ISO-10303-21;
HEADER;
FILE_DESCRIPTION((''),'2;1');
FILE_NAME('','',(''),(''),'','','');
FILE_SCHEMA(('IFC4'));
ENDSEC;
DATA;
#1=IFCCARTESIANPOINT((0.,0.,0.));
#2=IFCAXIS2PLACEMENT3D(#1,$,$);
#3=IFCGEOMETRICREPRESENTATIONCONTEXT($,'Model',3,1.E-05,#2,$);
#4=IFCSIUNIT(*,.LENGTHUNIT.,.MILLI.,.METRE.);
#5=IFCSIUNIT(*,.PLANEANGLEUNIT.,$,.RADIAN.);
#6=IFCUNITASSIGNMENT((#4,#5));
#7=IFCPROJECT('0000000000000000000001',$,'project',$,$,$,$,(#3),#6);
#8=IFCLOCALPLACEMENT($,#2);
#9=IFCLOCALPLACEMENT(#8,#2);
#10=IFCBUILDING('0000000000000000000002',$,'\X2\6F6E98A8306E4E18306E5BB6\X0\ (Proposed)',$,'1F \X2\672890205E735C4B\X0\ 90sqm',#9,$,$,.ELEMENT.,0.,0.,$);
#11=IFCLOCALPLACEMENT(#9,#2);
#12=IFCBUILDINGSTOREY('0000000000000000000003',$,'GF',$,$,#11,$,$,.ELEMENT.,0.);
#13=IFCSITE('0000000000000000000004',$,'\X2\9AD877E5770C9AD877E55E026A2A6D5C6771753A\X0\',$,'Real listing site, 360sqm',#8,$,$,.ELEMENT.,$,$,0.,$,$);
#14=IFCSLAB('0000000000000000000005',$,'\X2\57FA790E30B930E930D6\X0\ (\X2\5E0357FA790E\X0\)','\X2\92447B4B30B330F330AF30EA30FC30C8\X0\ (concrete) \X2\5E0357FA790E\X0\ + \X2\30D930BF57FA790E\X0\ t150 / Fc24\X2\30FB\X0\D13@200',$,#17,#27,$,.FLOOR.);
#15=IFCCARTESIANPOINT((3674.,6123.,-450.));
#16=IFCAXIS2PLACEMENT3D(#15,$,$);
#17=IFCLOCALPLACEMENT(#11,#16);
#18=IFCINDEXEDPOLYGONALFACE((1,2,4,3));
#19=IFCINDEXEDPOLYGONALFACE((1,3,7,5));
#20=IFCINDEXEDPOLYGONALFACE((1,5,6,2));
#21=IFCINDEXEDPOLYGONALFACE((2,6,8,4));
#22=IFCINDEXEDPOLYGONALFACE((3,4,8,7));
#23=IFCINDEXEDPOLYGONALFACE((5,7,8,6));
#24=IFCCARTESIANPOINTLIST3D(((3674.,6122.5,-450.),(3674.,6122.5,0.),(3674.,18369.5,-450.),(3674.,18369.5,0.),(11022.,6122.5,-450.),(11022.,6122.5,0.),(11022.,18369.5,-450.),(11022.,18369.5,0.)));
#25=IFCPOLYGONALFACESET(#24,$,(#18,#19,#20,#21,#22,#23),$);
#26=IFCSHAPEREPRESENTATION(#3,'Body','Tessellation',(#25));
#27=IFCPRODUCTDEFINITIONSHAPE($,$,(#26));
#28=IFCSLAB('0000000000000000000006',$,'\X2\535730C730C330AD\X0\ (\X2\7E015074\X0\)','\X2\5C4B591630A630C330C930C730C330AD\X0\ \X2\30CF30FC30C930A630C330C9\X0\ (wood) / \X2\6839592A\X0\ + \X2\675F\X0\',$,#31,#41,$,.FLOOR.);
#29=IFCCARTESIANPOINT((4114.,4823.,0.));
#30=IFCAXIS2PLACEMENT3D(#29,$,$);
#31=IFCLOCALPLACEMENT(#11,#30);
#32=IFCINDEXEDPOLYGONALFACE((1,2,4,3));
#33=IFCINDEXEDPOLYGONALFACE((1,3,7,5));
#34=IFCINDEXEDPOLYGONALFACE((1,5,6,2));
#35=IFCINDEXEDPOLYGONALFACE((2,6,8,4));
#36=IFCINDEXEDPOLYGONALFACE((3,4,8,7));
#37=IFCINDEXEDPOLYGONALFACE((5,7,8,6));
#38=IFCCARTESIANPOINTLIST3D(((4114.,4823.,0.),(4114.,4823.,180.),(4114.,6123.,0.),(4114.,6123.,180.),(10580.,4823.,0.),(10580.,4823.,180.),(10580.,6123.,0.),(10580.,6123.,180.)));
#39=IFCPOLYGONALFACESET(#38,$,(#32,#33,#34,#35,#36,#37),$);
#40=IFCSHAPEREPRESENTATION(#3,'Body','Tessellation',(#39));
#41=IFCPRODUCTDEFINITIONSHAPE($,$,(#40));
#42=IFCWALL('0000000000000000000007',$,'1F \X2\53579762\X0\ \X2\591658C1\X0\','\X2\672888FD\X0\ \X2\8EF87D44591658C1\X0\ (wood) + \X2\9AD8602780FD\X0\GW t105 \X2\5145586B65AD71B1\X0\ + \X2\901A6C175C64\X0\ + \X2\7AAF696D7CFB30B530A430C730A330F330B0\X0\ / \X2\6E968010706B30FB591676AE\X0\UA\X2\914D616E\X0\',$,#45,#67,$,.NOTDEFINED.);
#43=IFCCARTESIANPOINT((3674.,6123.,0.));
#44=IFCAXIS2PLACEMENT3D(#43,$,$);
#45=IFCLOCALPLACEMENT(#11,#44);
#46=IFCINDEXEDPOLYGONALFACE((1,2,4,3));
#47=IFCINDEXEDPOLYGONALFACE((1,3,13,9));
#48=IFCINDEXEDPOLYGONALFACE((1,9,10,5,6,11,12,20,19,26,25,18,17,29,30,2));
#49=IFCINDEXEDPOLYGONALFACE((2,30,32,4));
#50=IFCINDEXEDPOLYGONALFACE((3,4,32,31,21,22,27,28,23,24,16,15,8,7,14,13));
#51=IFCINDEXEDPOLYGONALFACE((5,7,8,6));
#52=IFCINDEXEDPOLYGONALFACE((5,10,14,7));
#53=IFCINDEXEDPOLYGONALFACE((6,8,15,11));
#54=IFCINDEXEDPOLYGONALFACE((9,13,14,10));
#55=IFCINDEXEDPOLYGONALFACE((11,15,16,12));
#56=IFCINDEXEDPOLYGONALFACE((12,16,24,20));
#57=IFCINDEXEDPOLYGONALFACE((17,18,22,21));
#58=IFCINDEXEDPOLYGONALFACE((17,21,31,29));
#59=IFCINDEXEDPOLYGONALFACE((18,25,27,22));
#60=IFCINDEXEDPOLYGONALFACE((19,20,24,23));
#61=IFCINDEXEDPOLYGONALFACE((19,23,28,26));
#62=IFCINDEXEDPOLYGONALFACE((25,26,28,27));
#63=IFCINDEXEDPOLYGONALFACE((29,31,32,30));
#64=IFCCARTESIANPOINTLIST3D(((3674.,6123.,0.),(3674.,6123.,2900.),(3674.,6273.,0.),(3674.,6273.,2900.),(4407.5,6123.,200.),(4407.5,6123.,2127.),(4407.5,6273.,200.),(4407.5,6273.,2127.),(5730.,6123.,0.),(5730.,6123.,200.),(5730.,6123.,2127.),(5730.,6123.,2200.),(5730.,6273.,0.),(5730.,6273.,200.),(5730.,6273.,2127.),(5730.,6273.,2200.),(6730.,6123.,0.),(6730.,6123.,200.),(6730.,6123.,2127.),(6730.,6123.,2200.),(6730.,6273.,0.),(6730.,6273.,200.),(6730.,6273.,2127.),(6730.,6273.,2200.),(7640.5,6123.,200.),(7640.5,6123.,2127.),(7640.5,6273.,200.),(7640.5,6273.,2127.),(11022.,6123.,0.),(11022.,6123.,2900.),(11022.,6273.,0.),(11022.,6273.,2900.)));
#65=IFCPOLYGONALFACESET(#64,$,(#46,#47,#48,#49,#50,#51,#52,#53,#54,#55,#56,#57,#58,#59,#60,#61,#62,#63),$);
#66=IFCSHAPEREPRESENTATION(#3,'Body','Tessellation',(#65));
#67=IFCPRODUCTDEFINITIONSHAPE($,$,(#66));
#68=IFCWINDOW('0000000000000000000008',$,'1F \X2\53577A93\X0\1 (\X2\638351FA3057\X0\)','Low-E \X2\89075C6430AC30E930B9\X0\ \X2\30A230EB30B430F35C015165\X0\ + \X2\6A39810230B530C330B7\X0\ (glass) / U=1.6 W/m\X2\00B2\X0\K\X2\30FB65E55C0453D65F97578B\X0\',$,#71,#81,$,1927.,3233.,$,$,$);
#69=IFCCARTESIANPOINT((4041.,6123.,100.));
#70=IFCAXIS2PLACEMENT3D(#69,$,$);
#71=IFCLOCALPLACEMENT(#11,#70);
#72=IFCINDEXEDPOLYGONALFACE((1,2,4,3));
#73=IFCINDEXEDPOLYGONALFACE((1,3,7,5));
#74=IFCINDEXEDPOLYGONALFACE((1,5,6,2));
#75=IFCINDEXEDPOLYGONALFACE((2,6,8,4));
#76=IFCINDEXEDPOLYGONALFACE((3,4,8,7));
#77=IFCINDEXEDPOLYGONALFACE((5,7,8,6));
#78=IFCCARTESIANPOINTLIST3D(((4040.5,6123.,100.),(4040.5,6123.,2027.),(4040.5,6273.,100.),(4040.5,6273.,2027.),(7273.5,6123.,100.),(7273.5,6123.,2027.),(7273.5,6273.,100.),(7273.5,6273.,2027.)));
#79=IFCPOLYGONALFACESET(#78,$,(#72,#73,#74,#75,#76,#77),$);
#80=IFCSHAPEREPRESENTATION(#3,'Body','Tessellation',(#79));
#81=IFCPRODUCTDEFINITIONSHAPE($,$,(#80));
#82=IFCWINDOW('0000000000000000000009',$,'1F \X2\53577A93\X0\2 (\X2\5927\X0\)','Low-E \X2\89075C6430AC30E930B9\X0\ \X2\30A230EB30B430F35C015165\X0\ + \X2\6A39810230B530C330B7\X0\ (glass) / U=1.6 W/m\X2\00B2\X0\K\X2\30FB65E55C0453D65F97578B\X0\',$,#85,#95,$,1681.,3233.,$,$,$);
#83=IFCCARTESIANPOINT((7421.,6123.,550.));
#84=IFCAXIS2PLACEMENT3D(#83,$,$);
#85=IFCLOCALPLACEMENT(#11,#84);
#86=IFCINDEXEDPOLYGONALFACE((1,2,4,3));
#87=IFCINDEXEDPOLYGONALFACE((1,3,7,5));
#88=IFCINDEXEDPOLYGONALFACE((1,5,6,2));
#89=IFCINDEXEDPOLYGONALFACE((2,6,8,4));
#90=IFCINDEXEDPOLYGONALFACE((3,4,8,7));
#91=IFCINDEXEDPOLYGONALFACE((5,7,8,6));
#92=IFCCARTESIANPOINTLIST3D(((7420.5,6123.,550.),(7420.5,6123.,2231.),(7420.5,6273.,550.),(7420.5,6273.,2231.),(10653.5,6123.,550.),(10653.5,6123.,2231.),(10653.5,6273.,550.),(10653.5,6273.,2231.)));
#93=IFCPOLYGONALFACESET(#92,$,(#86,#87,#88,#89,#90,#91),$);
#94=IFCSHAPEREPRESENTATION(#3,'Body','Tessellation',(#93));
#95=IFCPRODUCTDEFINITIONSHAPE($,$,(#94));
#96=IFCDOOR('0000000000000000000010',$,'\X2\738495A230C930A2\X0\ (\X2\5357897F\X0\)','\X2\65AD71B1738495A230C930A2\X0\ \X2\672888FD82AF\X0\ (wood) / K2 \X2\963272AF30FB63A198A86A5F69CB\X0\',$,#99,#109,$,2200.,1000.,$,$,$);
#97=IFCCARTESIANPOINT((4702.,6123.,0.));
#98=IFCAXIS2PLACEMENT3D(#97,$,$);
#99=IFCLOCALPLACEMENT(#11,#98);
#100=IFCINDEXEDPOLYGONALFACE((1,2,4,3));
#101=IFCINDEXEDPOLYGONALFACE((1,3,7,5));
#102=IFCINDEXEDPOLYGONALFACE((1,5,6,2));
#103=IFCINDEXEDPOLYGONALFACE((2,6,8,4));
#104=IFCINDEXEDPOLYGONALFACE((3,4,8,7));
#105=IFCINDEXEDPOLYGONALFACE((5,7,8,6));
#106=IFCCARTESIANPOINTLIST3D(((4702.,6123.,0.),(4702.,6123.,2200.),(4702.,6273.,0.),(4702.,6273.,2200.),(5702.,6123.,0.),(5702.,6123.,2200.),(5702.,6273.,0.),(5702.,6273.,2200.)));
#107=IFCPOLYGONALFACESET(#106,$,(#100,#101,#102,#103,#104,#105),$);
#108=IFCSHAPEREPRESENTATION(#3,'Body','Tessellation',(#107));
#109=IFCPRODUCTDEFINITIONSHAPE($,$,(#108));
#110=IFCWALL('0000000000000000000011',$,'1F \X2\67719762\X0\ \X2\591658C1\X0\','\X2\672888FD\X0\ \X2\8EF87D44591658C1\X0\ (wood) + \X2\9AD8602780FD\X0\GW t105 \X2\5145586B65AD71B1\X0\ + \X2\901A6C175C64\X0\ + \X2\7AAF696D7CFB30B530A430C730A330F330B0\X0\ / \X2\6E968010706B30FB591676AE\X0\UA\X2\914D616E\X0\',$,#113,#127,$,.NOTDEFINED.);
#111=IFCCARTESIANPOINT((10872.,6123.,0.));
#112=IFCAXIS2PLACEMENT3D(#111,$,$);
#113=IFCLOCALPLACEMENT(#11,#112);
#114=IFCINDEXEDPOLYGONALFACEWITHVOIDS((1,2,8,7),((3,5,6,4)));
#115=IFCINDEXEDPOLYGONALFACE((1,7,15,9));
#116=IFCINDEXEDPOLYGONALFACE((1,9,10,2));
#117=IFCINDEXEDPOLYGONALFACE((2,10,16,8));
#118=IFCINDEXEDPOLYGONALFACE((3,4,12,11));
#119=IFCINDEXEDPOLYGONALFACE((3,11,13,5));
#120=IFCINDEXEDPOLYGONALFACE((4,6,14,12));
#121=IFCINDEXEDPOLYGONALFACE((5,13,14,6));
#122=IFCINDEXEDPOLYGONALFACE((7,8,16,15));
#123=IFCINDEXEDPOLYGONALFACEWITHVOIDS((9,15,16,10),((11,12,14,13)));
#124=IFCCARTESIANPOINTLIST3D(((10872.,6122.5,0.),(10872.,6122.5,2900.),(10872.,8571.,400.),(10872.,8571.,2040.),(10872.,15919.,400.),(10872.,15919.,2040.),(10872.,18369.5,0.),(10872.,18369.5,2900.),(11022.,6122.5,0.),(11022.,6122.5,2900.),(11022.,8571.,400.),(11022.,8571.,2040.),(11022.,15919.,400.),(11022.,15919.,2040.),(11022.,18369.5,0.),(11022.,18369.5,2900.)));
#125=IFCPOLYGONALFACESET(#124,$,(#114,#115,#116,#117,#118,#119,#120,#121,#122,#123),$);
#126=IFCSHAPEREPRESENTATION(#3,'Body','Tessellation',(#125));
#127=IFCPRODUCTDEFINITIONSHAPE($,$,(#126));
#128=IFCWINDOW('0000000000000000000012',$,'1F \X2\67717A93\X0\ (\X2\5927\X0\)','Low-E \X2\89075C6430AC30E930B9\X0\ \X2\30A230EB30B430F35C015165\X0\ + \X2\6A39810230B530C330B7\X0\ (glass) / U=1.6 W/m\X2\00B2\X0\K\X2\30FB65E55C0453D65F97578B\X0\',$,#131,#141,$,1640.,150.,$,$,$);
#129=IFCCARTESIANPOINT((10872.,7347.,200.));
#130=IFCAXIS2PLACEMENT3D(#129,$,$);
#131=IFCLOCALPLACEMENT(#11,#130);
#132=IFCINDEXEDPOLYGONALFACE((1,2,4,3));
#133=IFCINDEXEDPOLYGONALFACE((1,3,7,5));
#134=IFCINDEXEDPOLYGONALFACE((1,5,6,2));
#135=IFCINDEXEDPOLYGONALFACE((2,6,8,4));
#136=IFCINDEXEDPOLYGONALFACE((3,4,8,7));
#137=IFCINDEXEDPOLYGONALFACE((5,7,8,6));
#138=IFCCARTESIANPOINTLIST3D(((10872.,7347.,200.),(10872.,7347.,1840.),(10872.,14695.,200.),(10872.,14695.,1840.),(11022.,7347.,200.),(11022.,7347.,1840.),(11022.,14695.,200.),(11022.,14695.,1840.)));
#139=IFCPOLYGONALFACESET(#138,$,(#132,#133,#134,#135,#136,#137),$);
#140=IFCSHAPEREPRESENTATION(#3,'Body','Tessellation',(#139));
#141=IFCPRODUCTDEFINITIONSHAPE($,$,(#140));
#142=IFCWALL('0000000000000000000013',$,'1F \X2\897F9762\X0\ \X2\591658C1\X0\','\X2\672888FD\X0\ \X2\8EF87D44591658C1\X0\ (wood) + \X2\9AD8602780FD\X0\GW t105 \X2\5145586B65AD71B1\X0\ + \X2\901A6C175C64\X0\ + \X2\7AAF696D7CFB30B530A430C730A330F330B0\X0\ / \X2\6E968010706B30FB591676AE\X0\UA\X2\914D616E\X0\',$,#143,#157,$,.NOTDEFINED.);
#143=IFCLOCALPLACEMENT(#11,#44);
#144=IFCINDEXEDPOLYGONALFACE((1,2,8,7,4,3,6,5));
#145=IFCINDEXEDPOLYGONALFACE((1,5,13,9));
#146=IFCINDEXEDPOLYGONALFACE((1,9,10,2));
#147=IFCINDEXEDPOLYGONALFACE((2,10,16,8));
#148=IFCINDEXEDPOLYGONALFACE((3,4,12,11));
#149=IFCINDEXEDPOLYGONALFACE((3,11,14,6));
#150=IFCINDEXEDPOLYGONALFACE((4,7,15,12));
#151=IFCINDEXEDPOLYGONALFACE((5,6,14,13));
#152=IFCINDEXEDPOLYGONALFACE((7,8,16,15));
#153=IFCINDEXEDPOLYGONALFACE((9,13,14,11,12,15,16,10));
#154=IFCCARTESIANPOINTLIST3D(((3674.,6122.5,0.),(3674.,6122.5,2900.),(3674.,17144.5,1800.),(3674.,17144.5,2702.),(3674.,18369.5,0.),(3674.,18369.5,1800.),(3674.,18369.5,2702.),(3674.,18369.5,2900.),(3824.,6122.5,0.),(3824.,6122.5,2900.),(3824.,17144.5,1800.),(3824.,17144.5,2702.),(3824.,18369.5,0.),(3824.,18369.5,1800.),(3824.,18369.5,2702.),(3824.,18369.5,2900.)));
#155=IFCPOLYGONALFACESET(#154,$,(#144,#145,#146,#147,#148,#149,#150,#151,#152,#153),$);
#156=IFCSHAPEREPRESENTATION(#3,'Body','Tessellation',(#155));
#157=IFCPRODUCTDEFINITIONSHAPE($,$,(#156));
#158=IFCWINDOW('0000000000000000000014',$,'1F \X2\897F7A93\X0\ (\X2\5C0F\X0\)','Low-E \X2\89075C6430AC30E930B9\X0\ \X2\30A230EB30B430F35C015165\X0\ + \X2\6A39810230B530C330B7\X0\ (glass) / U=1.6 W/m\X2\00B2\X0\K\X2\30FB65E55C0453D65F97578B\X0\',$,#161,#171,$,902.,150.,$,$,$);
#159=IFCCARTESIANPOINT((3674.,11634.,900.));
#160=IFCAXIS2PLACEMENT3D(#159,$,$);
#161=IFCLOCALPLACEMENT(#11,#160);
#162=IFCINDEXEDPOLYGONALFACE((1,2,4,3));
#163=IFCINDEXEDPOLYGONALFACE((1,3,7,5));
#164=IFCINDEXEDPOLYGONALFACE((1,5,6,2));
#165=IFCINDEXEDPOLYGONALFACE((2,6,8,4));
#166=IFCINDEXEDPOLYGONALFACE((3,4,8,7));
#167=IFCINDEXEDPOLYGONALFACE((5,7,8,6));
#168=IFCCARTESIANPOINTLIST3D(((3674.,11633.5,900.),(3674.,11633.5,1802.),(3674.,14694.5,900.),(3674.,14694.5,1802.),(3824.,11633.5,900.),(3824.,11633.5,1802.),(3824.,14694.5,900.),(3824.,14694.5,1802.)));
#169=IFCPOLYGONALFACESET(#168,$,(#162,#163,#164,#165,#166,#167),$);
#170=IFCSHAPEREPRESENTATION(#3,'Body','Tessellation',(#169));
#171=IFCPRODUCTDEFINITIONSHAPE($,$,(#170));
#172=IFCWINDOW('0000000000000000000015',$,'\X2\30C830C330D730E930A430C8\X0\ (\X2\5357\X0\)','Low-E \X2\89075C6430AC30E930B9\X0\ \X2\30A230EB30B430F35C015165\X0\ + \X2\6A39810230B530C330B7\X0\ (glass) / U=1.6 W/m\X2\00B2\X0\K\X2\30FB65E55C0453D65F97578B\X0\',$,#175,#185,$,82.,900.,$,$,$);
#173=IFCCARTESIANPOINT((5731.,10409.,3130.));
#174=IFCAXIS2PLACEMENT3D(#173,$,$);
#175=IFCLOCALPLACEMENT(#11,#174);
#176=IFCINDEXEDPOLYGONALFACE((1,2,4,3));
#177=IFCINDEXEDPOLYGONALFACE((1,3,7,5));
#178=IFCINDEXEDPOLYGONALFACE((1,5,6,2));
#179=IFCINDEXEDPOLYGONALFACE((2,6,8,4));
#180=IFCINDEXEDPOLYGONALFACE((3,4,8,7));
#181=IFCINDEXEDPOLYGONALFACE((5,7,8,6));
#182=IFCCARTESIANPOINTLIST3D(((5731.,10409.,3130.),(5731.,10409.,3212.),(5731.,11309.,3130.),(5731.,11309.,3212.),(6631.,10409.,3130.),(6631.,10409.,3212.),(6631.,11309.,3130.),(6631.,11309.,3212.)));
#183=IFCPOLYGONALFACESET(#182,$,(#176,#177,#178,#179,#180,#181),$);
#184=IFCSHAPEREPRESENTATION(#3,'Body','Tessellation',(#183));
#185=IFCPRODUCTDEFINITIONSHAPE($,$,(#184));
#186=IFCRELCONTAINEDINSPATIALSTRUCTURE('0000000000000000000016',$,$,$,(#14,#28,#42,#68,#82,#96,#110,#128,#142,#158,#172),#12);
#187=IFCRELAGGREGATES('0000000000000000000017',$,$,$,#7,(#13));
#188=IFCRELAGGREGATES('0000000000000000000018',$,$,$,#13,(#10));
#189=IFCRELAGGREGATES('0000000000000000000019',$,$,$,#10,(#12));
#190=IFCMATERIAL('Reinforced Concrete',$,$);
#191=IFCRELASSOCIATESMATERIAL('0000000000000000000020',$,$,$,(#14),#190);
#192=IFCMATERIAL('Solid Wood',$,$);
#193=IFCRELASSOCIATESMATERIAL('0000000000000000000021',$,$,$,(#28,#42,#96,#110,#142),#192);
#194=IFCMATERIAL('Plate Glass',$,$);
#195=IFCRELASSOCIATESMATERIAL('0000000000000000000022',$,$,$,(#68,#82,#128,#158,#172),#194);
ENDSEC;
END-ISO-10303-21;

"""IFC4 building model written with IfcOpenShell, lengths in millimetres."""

from ifc_helpers import new_model, si_unit, frame, frame_2d, origin, place, context, project, spatial, rectangle, extrude, material, element, fill, save


model = new_model("IFC4")

# Units and contexts
model_context = context("Model", 3, precision=1e-05, world=origin())
ifc_project = project(units=[si_unit("LENGTHUNIT", "METRE", prefix="MILLI"), si_unit("PLANEANGLEUNIT", "RADIAN")], contexts=[model_context])

# Site, building, storey
site_placement = place(None, origin())
site = spatial("IfcSite", under=ifc_project, at=site_placement, Name="高知県高知市横浜東町", ObjectType="Real listing site, 360sqm", CompositionType="ELEMENT", RefElevation=0.0)
building_placement = place(site_placement, origin())
building = spatial("IfcBuilding", under=site, at=building_placement, Name="潮風の丘の家 (Proposed)", ObjectType="1F 木造平屋 90sqm", CompositionType="ELEMENT", ElevationOfRefHeight=0.0, ElevationOfTerrain=0.0)
storey_placement = place(building_placement, origin())
storey = spatial("IfcBuildingStorey", under=building, at=storey_placement, Name="GF", CompositionType="ELEMENT", Elevation=0.0)

# Slabs
ifc_material_1 = material(Name="Reinforced Concrete")
slab_1_placement = place(storey_placement, frame((3674.0, 6123.0, -450.0)))
element("IfcSlab", 1, at=slab_1_placement, inside=storey, material=ifc_material_1, Name="基礎スラブ (布基礎)", Description="鉄筋コンクリート (concrete) 布基礎 + ベタ基礎 t150 / Fc24・D13@200", PredefinedType="FLOOR", context=model_context, shape_type="SweptSolid", body=[
    extrude(rectangle(XDim=7348.0, YDim=12247.0, at=frame_2d((3674.0, 6123.0))), frame((3674.0, 6123.0, -450.0)), (0.0, 0.0, 1.0), 450.0),
])
ifc_material_2 = material(Name="Solid Wood")
slab_2_placement = place(storey_placement, frame((4114.0, 4823.0, 0.0)))
element("IfcSlab", 2, at=slab_2_placement, inside=storey, material=ifc_material_2, Name="南デッキ (縁側)", Description="屋外ウッドデッキ ハードウッド (wood) / 根太 + 束", PredefinedType="FLOOR", context=model_context, shape_type="SweptSolid", body=[
    extrude(rectangle(XDim=6466.0, YDim=1300.0, at=frame_2d((3233.0, 650.0))), frame((4114.0, 4823.0, 0.0)), (0.0, 0.0, 1.0), 180.0),
])

# Wall, openings, windows, door
wall_1_placement = place(storey_placement, frame((3674.0, 6123.0, 0.0)))
wall_1 = element("IfcWall", 3, at=wall_1_placement, inside=storey, material=ifc_material_2, Name="1F 南面 外壁", Description="木製 軸組外壁 (wood) + 高性能GW t105 充填断熱 + 通気層 + 窯業系サイディング / 準耐火・外皮UA配慮", PredefinedType="NOTDEFINED", context=model_context, shape_type="SweptSolid", body=[
    extrude(rectangle(XDim=7348.0, YDim=150.0, at=frame_2d((3674.0, 75.0))), frame((3674.0, 6123.0, 0.0)), (0.0, 0.0, 1.0), 2900.0),
])
opening_1_placement = place(storey_placement, frame((4041.0, 6123.0, 100.0)))
opening_1 = element("IfcOpeningElement", 4, at=opening_1_placement, cuts=wall_1, PredefinedType="NOTDEFINED", context=model_context, shape_type="SweptSolid", body=[
    extrude(rectangle(XDim=3233.0, YDim=150.0, at=frame_2d((1616.0, 75.0))), frame((4041.0, 6123.0, 100.0)), (0.0, 0.0, 1.0), 1927.0),
])
opening_2_placement = place(storey_placement, frame((7421.0, 6123.0, 550.0)))
opening_2 = element("IfcOpeningElement", 5, at=opening_2_placement, cuts=wall_1, PredefinedType="NOTDEFINED", context=model_context, shape_type="SweptSolid", body=[
    extrude(rectangle(XDim=3233.0, YDim=150.0, at=frame_2d((1616.0, 75.0))), frame((7421.0, 6123.0, 550.0)), (0.0, 0.0, 1.0), 1681.0),
])
opening_3_placement = place(storey_placement, frame((4702.0, 6123.0, 0.0)))
opening_3 = element("IfcOpeningElement", 6, at=opening_3_placement, cuts=wall_1, PredefinedType="NOTDEFINED", context=model_context, shape_type="SweptSolid", body=[
    extrude(rectangle(XDim=1000.0, YDim=150.0, at=frame_2d((500.0, 75.0))), frame((4702.0, 6123.0, 0.0)), (0.0, 0.0, 1.0), 2200.0),
])
ifc_material_3 = material(Name="Plate Glass")
window_1_placement = place(storey_placement, frame((4041.0, 6123.0, 100.0)))
window_1 = element("IfcWindow", 7, at=window_1_placement, inside=storey, material=ifc_material_3, Name="1F 南窓1 (掃出し)", Description="Low-E 複層ガラス アルゴン封入 + 樹脂サッシ (glass) / U=1.6 W/m²K・日射取得型", OverallHeight=1927.0, OverallWidth=3233.0, context=model_context, shape_type="SweptSolid", body=[
    extrude(rectangle(XDim=3233.0, YDim=150.0, at=frame_2d((1616.0, 75.0))), frame((4041.0, 6123.0, 100.0)), (0.0, 0.0, 1.0), 1927.0),
])
fill(opening_1, window_1)
window_2_placement = place(storey_placement, frame((7421.0, 6123.0, 550.0)))
window_2 = element("IfcWindow", 8, at=window_2_placement, inside=storey, material=ifc_material_3, Name="1F 南窓2 (大)", Description="Low-E 複層ガラス アルゴン封入 + 樹脂サッシ (glass) / U=1.6 W/m²K・日射取得型", OverallHeight=1681.0, OverallWidth=3233.0, context=model_context, shape_type="SweptSolid", body=[
    extrude(rectangle(XDim=3233.0, YDim=150.0, at=frame_2d((1616.0, 75.0))), frame((7421.0, 6123.0, 550.0)), (0.0, 0.0, 1.0), 1681.0),
])
fill(opening_2, window_2)
door_placement = place(storey_placement, frame((4702.0, 6123.0, 0.0)))
door = element("IfcDoor", 9, at=door_placement, inside=storey, material=ifc_material_2, Name="玄関ドア (南西)", Description="断熱玄関ドア 木製芯 (wood) / K2 防犯・採風機構", OverallHeight=2200.0, OverallWidth=1000.0, context=model_context, shape_type="SweptSolid", body=[
    extrude(rectangle(XDim=1000.0, YDim=150.0, at=frame_2d((500.0, 75.0))), frame((4702.0, 6123.0, 0.0)), (0.0, 0.0, 1.0), 2200.0),
])
fill(opening_3, door)

# Walls, openings, windows
wall_2_placement = place(storey_placement, frame((10872.0, 6123.0, 0.0)))
wall_2 = element("IfcWall", 10, at=wall_2_placement, inside=storey, material=ifc_material_2, Name="1F 東面 外壁", Description="木製 軸組外壁 (wood) + 高性能GW t105 充填断熱 + 通気層 + 窯業系サイディング / 準耐火・外皮UA配慮", PredefinedType="NOTDEFINED", context=model_context, shape_type="SweptSolid", body=[
    extrude(rectangle(XDim=150.0, YDim=12247.0, at=frame_2d((75.0, 6123.0))), frame((10872.0, 6123.0, 0.0)), (0.0, 0.0, 1.0), 2900.0),
])
opening_4_placement = place(storey_placement, frame((10872.0, 7347.0, 200.0)))
opening_4 = element("IfcOpeningElement", 11, at=opening_4_placement, cuts=wall_2, PredefinedType="NOTDEFINED", context=model_context, shape_type="SweptSolid", body=[
    extrude(rectangle(XDim=150.0, YDim=7348.0, at=frame_2d((75.0, 3674.0))), frame((10872.0, 7347.0, 200.0)), (0.0, 0.0, 1.0), 1640.0),
])
window_3_placement = place(storey_placement, frame((10872.0, 7347.0, 200.0)))
window_3 = element("IfcWindow", 12, at=window_3_placement, inside=storey, material=ifc_material_3, Name="1F 東窓 (大)", Description="Low-E 複層ガラス アルゴン封入 + 樹脂サッシ (glass) / U=1.6 W/m²K・日射取得型", OverallHeight=1640.0, OverallWidth=150.0, context=model_context, shape_type="SweptSolid", body=[
    extrude(rectangle(XDim=150.0, YDim=7348.0, at=frame_2d((75.0, 3674.0))), frame((10872.0, 7347.0, 200.0)), (0.0, 0.0, 1.0), 1640.0),
])
fill(opening_4, window_3)
wall_3_placement = place(storey_placement, frame((3674.0, 6123.0, 0.0)))
wall_3 = element("IfcWall", 13, at=wall_3_placement, inside=storey, material=ifc_material_2, Name="1F 西面 外壁", Description="木製 軸組外壁 (wood) + 高性能GW t105 充填断熱 + 通気層 + 窯業系サイディング / 準耐火・外皮UA配慮", PredefinedType="NOTDEFINED", context=model_context, shape_type="SweptSolid", body=[
    extrude(rectangle(XDim=150.0, YDim=12247.0, at=frame_2d((75.0, 6123.0))), frame((3674.0, 6123.0, 0.0)), (0.0, 0.0, 1.0), 2900.0),
])
opening_5_placement = place(storey_placement, frame((3674.0, 11634.0, 900.0)))
opening_5 = element("IfcOpeningElement", 14, at=opening_5_placement, cuts=wall_3, PredefinedType="NOTDEFINED", context=model_context, shape_type="SweptSolid", body=[
    extrude(rectangle(XDim=150.0, YDim=3061.0, at=frame_2d((75.0, 1530.0))), frame((3674.0, 11634.0, 900.0)), (0.0, 0.0, 1.0), 902.0),
])
window_4_placement = place(storey_placement, frame((3674.0, 11634.0, 900.0)))
window_4 = element("IfcWindow", 15, at=window_4_placement, inside=storey, material=ifc_material_3, Name="1F 西窓 (小)", Description="Low-E 複層ガラス アルゴン封入 + 樹脂サッシ (glass) / U=1.6 W/m²K・日射取得型", OverallHeight=902.0, OverallWidth=150.0, context=model_context, shape_type="SweptSolid", body=[
    extrude(rectangle(XDim=150.0, YDim=3061.0, at=frame_2d((75.0, 1530.0))), frame((3674.0, 11634.0, 900.0)), (0.0, 0.0, 1.0), 902.0),
])
fill(opening_5, window_4)

# Window
window_5_placement = place(storey_placement, frame((5731.0, 10409.0, 3130.0)))
element("IfcWindow", 16, at=window_5_placement, inside=storey, material=ifc_material_3, Name="トップライト (南)", Description="Low-E 複層ガラス アルゴン封入 + 樹脂サッシ (glass) / U=1.6 W/m²K・日射取得型", OverallHeight=82.0, OverallWidth=900.0, context=model_context, shape_type="SweptSolid", body=[
    extrude(rectangle(XDim=900.0, YDim=900.0, at=frame_2d((450.0, 450.0))), frame((5731.0, 10409.0, 3130.0)), (0.0, 0.0, 1.0), 82.0),
])

save(model, "model.ifc")
